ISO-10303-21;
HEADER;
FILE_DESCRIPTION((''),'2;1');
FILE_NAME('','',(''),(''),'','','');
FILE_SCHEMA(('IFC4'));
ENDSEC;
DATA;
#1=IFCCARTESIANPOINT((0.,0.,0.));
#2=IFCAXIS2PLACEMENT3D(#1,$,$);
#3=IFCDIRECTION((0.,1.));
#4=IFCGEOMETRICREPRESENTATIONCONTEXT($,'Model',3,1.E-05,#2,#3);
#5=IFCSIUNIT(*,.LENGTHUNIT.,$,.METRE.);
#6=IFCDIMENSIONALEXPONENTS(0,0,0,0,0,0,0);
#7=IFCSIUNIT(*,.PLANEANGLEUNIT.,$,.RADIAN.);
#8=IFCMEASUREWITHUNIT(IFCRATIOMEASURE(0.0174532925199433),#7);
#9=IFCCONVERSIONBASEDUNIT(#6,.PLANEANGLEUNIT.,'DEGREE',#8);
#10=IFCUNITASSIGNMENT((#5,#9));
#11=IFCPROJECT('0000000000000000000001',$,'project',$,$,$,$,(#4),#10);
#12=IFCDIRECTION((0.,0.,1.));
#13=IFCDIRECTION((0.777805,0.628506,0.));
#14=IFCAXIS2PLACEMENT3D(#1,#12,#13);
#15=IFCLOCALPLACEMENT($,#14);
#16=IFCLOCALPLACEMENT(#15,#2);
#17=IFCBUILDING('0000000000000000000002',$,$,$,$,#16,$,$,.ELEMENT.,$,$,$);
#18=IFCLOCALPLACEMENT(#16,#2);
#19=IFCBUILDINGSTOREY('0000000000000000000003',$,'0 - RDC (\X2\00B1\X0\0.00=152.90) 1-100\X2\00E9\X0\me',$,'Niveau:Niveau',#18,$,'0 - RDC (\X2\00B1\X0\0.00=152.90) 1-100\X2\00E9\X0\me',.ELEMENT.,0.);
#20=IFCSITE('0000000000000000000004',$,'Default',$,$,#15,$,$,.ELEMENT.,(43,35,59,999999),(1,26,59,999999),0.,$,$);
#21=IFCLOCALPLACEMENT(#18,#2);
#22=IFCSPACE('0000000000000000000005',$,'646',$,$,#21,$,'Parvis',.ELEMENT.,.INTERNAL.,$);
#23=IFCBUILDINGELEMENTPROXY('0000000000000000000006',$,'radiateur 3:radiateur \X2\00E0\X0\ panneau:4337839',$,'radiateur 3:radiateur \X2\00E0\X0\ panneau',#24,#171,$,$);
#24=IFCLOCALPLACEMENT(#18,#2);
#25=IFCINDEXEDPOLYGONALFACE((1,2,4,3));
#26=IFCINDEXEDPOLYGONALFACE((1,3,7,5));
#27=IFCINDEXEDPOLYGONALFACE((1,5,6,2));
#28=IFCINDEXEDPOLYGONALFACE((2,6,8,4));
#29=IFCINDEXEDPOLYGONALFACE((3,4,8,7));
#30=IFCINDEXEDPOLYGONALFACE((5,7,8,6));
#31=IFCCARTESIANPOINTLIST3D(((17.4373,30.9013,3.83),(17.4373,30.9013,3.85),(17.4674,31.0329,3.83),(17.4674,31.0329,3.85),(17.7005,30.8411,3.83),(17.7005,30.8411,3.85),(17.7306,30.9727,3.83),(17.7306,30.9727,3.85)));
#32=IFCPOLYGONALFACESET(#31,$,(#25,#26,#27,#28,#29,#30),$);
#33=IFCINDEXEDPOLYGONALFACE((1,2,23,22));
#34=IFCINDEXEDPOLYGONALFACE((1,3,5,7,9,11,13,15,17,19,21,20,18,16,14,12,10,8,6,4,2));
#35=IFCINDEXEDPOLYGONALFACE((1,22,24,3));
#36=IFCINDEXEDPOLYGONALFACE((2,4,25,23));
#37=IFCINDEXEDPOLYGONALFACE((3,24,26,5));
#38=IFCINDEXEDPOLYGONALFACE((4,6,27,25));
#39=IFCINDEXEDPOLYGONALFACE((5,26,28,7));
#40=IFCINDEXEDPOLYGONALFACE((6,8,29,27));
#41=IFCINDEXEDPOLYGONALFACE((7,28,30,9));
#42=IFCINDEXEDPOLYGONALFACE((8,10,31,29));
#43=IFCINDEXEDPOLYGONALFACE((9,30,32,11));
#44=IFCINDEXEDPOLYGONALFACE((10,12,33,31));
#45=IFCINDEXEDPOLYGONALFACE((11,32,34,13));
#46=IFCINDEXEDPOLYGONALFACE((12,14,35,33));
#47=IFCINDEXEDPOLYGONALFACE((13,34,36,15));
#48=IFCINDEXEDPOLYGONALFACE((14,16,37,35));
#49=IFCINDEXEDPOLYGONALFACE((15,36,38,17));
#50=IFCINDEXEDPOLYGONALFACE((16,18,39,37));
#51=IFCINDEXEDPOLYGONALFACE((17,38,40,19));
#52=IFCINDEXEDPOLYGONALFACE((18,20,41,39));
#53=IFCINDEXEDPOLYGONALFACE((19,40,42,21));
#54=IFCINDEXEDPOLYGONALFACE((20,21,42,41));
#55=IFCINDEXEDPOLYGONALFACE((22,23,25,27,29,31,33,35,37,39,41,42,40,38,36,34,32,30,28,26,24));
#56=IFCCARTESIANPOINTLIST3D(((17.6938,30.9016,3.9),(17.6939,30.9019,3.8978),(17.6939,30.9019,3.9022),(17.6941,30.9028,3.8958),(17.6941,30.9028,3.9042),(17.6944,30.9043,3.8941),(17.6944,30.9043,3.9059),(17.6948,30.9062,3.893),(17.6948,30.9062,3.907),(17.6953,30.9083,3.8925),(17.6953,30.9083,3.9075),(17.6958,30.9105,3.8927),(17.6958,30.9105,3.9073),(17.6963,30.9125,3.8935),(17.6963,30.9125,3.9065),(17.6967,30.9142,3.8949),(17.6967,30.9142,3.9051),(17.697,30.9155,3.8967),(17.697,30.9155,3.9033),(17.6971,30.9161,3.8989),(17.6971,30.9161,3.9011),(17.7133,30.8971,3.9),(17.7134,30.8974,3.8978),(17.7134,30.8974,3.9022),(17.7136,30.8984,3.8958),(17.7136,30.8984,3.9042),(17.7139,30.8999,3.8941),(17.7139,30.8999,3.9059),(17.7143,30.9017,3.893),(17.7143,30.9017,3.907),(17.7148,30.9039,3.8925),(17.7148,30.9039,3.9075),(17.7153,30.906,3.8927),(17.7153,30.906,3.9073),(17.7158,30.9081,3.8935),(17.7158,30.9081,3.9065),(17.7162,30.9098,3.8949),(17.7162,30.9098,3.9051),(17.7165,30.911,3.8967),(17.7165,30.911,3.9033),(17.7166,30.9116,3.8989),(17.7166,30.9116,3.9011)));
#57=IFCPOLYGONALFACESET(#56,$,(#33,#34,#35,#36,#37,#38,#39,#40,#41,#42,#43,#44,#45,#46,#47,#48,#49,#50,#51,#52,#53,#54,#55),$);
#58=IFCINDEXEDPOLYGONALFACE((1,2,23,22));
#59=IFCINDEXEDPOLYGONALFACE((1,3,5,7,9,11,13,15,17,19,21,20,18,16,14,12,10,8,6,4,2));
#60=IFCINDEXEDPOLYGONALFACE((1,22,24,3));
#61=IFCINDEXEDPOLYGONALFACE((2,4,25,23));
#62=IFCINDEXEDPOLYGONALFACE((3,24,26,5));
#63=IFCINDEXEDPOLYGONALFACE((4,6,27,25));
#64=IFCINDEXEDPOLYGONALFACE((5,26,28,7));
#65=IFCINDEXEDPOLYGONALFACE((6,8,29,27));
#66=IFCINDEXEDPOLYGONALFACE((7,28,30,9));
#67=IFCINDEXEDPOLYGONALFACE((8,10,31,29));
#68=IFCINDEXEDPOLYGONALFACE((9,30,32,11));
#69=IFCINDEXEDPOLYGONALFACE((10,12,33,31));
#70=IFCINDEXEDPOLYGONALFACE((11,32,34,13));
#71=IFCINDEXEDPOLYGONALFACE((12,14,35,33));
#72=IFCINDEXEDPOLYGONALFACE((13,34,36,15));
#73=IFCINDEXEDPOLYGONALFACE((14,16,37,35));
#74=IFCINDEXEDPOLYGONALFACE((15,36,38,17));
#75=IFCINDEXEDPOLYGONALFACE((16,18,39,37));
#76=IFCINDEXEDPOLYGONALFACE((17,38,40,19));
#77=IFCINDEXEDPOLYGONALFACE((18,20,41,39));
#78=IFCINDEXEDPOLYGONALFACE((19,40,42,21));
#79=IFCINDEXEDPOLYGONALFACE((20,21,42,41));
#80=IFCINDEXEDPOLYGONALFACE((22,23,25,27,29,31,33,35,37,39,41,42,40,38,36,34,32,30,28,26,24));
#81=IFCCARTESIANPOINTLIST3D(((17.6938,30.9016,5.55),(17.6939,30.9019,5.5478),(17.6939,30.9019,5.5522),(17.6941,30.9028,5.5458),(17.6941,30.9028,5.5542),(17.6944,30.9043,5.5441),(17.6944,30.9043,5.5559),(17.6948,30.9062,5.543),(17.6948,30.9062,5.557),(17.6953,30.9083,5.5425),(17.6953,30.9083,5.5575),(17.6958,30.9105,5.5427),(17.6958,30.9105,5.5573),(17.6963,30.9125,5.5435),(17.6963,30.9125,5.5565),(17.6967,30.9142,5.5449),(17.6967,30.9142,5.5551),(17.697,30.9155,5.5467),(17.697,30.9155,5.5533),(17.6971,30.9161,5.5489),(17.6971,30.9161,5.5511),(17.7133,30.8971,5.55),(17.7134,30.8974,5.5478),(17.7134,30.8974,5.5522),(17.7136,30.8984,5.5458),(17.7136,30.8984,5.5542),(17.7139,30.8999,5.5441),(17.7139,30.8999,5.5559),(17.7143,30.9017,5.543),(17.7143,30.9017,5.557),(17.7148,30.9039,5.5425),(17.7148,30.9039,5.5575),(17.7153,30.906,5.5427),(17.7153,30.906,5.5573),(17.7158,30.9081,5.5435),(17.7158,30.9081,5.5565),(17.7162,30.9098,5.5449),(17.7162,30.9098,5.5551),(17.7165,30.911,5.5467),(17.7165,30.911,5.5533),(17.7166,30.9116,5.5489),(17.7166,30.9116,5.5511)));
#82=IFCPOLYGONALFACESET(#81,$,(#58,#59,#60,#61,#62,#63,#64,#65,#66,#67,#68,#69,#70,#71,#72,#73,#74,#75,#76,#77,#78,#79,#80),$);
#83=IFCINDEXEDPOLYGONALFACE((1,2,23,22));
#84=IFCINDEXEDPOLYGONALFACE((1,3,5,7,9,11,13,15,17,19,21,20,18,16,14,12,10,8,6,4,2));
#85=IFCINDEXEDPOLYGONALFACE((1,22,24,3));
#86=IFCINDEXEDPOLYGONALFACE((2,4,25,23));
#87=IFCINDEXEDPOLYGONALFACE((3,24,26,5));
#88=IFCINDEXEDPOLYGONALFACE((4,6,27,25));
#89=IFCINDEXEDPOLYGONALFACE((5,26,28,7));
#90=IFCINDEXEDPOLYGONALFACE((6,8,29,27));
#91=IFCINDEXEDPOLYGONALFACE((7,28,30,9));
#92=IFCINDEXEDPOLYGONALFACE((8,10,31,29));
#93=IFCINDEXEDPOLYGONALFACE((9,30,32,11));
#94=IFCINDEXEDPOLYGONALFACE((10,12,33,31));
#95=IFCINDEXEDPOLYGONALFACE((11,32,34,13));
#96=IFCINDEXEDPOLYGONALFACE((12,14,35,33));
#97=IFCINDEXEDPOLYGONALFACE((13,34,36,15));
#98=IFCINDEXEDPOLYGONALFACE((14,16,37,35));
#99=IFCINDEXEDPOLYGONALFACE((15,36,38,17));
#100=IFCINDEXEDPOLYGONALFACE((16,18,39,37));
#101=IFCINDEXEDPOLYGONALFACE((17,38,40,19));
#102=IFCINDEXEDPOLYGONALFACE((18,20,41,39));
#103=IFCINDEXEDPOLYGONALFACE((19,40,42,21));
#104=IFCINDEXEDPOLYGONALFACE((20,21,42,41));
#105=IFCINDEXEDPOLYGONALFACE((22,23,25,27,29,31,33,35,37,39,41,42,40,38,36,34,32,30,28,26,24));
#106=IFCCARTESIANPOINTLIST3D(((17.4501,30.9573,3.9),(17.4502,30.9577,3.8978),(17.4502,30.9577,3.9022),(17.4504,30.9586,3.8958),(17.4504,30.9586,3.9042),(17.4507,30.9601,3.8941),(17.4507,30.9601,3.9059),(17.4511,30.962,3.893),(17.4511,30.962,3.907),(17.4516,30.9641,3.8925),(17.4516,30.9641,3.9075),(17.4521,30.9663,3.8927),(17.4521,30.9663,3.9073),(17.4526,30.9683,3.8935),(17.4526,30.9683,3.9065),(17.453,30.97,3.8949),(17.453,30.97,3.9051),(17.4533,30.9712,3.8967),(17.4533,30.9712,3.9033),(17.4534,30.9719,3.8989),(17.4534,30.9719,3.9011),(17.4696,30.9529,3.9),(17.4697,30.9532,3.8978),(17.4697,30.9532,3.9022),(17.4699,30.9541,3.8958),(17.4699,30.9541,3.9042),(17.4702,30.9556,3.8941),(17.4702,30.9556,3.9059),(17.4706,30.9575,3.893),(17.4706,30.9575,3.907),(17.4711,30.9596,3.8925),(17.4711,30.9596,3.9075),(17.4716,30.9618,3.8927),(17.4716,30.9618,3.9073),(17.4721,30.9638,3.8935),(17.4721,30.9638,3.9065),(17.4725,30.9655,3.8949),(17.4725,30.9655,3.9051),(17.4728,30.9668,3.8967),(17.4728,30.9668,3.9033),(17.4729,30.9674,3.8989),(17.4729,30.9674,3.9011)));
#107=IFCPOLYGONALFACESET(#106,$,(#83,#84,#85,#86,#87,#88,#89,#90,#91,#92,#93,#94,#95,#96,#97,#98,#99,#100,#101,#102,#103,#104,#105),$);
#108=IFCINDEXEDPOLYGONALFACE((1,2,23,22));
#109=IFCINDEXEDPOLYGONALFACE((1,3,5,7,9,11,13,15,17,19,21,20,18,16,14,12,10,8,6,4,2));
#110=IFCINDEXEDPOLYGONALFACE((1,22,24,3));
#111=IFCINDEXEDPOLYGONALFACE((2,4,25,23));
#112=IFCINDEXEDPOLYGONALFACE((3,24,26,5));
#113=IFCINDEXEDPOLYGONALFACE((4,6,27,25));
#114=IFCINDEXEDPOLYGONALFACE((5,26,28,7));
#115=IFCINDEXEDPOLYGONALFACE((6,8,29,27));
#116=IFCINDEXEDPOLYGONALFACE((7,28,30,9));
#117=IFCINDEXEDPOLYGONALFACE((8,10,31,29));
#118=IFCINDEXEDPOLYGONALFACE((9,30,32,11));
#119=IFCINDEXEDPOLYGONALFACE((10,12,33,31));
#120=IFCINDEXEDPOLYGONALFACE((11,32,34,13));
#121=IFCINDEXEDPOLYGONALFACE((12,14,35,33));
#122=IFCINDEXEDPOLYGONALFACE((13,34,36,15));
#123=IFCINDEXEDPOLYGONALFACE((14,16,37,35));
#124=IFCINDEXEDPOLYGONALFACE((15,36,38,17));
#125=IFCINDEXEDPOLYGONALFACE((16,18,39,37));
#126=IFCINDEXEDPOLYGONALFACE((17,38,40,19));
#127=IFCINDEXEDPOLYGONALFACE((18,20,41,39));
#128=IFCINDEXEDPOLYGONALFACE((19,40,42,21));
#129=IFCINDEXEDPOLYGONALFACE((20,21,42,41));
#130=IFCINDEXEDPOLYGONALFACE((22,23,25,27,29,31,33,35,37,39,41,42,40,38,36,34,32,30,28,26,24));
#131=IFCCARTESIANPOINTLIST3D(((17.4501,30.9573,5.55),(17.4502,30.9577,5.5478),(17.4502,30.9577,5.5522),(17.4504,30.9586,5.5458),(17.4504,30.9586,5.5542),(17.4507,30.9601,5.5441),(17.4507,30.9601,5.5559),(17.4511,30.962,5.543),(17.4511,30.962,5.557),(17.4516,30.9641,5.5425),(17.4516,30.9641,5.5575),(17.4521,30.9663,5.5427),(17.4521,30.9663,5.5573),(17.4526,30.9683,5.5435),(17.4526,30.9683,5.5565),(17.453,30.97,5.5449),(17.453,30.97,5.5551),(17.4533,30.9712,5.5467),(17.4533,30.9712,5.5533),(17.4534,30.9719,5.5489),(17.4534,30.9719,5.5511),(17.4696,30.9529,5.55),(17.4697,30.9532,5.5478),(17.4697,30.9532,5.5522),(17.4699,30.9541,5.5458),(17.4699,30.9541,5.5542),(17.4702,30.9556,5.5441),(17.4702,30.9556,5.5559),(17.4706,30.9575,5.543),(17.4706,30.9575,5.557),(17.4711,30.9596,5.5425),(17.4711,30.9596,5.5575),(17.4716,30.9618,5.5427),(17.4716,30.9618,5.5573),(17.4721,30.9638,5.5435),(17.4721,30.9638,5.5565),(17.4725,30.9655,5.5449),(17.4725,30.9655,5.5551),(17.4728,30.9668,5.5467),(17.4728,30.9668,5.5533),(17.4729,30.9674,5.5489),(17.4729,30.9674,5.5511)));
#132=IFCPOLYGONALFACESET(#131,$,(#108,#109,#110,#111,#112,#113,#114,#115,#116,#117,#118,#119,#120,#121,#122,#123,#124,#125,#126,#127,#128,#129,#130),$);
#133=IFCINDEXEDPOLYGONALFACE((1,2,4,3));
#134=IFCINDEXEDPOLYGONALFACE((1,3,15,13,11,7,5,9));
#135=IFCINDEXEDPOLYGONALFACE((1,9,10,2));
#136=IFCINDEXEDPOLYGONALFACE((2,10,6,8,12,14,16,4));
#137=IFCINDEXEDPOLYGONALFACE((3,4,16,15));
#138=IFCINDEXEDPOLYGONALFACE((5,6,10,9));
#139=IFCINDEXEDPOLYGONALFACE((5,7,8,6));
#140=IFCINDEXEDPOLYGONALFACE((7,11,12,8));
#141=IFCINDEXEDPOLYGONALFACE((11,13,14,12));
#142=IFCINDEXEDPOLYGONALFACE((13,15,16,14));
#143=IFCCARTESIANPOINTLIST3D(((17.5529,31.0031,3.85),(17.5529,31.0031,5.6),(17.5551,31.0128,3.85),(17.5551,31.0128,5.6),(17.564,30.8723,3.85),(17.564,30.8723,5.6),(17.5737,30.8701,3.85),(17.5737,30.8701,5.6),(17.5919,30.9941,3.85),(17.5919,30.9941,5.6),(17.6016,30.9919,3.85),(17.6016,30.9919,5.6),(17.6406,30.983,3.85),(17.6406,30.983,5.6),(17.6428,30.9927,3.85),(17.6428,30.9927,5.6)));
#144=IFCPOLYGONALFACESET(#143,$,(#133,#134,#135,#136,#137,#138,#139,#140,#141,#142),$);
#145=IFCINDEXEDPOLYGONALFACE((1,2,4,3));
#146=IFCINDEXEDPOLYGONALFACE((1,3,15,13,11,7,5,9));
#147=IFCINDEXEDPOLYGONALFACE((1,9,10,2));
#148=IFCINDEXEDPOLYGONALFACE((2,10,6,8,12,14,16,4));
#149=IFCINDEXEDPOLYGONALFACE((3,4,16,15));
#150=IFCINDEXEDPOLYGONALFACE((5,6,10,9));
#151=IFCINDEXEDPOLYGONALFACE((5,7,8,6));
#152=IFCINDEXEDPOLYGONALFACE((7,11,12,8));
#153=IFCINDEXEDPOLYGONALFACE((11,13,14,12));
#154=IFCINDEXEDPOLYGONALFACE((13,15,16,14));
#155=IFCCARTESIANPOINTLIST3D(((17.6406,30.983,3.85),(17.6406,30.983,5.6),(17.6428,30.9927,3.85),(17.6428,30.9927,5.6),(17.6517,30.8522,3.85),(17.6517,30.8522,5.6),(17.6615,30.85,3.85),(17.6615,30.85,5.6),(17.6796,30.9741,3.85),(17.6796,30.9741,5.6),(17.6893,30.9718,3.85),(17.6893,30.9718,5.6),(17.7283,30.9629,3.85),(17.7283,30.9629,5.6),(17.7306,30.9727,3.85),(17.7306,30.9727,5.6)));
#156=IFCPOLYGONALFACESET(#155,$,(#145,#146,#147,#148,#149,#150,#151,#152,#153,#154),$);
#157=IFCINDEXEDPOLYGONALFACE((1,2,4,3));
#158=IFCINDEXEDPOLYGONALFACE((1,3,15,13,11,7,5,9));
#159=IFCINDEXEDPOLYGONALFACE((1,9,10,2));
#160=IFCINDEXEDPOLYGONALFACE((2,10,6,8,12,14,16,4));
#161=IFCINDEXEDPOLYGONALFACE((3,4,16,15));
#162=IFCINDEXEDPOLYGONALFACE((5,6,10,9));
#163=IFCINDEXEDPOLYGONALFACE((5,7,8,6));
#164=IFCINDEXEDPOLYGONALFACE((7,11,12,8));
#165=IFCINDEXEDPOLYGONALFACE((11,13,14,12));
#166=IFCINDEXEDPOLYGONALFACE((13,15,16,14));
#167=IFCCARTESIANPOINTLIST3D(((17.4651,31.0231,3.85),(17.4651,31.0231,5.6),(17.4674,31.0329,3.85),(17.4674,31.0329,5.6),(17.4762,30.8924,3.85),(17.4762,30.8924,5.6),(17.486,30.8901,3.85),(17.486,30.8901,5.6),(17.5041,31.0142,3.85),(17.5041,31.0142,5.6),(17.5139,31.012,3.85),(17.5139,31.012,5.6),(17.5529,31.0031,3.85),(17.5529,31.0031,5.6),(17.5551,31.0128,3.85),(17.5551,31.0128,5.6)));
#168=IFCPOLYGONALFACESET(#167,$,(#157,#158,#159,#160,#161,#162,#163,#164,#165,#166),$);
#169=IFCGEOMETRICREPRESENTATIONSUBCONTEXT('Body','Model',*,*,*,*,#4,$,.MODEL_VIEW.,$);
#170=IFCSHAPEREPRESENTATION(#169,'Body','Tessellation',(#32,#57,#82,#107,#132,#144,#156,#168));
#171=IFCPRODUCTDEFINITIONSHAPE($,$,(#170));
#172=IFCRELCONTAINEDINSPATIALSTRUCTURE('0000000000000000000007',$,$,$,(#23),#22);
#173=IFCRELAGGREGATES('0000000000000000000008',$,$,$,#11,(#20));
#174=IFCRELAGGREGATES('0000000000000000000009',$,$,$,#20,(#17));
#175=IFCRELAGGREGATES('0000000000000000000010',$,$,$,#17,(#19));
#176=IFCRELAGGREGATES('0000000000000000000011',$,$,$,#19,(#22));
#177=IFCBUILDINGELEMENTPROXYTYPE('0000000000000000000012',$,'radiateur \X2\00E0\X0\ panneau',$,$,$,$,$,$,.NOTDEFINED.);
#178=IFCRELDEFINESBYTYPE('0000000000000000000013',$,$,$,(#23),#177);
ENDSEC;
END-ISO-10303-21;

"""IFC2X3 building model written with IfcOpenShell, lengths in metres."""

from ifc_helpers import new_model, entity, si_unit, converted_unit, direction, frame, frame_2d, origin, origin_2d_with_axis, place, context, subcontext, project, spatial, polyline, rectangle, circle, outline, extrude, source, transform, mapped, type_object, type_shapes, element, save


model = new_model("IFC2X3")

# Units and contexts
model_context = context("Model", 3, precision=1e-05, world=origin(), true_north=direction((0.0, 1.0)))
body_context = subcontext(model_context, "Body", "Model", "MODEL_VIEW")
ifc_project = project(units=[si_unit("LENGTHUNIT", "METRE"), converted_unit("PLANEANGLEUNIT", "DEGREE", entity("IfcRatioMeasure", 0.0174532925199433), si_unit("PLANEANGLEUNIT", "RADIAN"), dimensions=[0, 0, 0, 0, 0, 0, 0])], contexts=[model_context])

# Site, building, storey
site_placement = place(None, frame((0.0, 0.0, 0.0), z_axis=(0.0, 0.0, 1.0), x_axis=(0.777805, 0.628506, 0.0)))
site = spatial("IfcSite", under=ifc_project, at=site_placement, Name="Default", CompositionType="ELEMENT", RefLatitude=(43, 35, 59, 999999), RefLongitude=(1, 26, 59, 999999), RefElevation=0.0)
building_placement = place(site_placement, origin())
building = spatial("IfcBuilding", under=site, at=building_placement, CompositionType="ELEMENT")
storey_placement = place(building_placement, origin())
storey = spatial("IfcBuildingStorey", under=building, at=storey_placement, Name="0 - RDC (±0.00=152.90) 1-100éme", ObjectType="Niveau:Niveau", LongName="0 - RDC (±0.00=152.90) 1-100éme", CompositionType="ELEMENT", Elevation=0.0)

# Shared definitions
space_1_placement = place(storey_placement, origin())
space_1 = spatial("IfcSpace", under=storey, at=space_1_placement, Name="646", LongName="Parvis", CompositionType="ELEMENT", InteriorOrExteriorSpace="INTERNAL")

# Building element proxy
building_element_proxy_type_1 = type_object("IfcBuildingElementProxyType", Name="radiateur à panneau", PredefinedType="NOTDEFINED")
shared_shape_1 = source(origin(), body_context, "Body", "SweptSolid", [
    extrude(rectangle(XDim=0.27, YDim=0.135, at=frame_2d((0.0, 0.0), x_axis=(1.0, 0.0))), frame((0.135, 0.0025, -0.02)), (0.0, 0.0, 1.0), 0.02),
    extrude(circle(Radius=0.0075, at=frame_2d((0.0, 0.0), x_axis=(1.0, 0.0))), frame((0.25, 0.0, 0.05), z_axis=(1.0, 0.0, 0.0), x_axis=(0.0, -1.0, 0.0)), (0.0, 0.0, 1.0), 0.02),
    extrude(circle(Radius=0.0075, at=frame_2d((0.0, 0.0), x_axis=(1.0, 0.0))), frame((0.25, 0.0, 1.7), z_axis=(1.0, 0.0, 0.0), x_axis=(0.0, -1.0, 0.0)), (0.0, 0.0, 1.0), 0.02),
    extrude(circle(Radius=0.0075, at=frame_2d((0.0, 0.0), x_axis=(1.0, 0.0))), frame((0.0, 0.0, 0.05), z_axis=(1.0, 0.0, 0.0), x_axis=(0.0, -1.0, 0.0)), (0.0, 0.0, 1.0), 0.02),
    extrude(circle(Radius=0.0075, at=origin_2d_with_axis()), frame((0.0, 0.0, 1.7), z_axis=(1.0, 0.0, 0.0), x_axis=(0.0, -1.0, 0.0)), (0.0, 0.0, 1.0), 0.02),
    extrude(outline(polyline([(-0.0963, 0.005), (-0.0963, -0.005), (0.0288, -0.005), (0.0288, -0.045), (0.0387, -0.045), (0.0387, 0.045), (0.0288, 0.045), (0.0288, 0.005), (-0.0963, 0.005)])), frame((0.135, 0.0313, 0.0), z_axis=(0.0, 0.0, -1.0), x_axis=(0.0, 1.0, 0.0)), (0.0, 0.0, -1.0), 1.75),
    extrude(outline(polyline([(-0.0963, 0.005), (-0.0963, -0.005), (0.0288, -0.005), (0.0288, -0.045), (0.0387, -0.045), (0.0387, 0.045), (0.0288, 0.045), (0.0288, 0.005), (-0.0963, 0.005)])), frame((0.225, 0.0313, 0.0), z_axis=(0.0, 0.0, -1.0), x_axis=(0.0, 1.0, 0.0)), (0.0, 0.0, -1.0), 1.75),
    extrude(outline(polyline([(-0.0963, 0.005), (-0.0963, -0.005), (0.0288, -0.005), (0.0288, -0.045), (0.0387, -0.045), (0.0387, 0.045), (0.0288, 0.045), (0.0288, 0.005), (-0.0963, 0.005)])), frame((0.045, 0.0313, 0.0), z_axis=(0.0, 0.0, -1.0), x_axis=(0.0, 1.0, 0.0)), (0.0, 0.0, -1.0), 1.75),
])
type_shapes(building_element_proxy_type_1, [shared_shape_1])
proxy_1_placement = place(space_1_placement, frame((17.4518, 30.9647, 3.85), z_axis=(0.0, 0.0, 1.0), x_axis=(0.974801, -0.223075, 0.0)))
element("IfcBuildingElementProxy", 1, at=proxy_1_placement, inside=space_1, type_object=building_element_proxy_type_1, Name="radiateur 3:radiateur à panneau:4337839", ObjectType="radiateur 3:radiateur à panneau", context=body_context, shape_type="MappedRepresentation", body=[
    mapped(shared_shape_1, transform((0.0, 0.0, 0.0), scale=1.0)),
])

save(model, "model.ifc")
